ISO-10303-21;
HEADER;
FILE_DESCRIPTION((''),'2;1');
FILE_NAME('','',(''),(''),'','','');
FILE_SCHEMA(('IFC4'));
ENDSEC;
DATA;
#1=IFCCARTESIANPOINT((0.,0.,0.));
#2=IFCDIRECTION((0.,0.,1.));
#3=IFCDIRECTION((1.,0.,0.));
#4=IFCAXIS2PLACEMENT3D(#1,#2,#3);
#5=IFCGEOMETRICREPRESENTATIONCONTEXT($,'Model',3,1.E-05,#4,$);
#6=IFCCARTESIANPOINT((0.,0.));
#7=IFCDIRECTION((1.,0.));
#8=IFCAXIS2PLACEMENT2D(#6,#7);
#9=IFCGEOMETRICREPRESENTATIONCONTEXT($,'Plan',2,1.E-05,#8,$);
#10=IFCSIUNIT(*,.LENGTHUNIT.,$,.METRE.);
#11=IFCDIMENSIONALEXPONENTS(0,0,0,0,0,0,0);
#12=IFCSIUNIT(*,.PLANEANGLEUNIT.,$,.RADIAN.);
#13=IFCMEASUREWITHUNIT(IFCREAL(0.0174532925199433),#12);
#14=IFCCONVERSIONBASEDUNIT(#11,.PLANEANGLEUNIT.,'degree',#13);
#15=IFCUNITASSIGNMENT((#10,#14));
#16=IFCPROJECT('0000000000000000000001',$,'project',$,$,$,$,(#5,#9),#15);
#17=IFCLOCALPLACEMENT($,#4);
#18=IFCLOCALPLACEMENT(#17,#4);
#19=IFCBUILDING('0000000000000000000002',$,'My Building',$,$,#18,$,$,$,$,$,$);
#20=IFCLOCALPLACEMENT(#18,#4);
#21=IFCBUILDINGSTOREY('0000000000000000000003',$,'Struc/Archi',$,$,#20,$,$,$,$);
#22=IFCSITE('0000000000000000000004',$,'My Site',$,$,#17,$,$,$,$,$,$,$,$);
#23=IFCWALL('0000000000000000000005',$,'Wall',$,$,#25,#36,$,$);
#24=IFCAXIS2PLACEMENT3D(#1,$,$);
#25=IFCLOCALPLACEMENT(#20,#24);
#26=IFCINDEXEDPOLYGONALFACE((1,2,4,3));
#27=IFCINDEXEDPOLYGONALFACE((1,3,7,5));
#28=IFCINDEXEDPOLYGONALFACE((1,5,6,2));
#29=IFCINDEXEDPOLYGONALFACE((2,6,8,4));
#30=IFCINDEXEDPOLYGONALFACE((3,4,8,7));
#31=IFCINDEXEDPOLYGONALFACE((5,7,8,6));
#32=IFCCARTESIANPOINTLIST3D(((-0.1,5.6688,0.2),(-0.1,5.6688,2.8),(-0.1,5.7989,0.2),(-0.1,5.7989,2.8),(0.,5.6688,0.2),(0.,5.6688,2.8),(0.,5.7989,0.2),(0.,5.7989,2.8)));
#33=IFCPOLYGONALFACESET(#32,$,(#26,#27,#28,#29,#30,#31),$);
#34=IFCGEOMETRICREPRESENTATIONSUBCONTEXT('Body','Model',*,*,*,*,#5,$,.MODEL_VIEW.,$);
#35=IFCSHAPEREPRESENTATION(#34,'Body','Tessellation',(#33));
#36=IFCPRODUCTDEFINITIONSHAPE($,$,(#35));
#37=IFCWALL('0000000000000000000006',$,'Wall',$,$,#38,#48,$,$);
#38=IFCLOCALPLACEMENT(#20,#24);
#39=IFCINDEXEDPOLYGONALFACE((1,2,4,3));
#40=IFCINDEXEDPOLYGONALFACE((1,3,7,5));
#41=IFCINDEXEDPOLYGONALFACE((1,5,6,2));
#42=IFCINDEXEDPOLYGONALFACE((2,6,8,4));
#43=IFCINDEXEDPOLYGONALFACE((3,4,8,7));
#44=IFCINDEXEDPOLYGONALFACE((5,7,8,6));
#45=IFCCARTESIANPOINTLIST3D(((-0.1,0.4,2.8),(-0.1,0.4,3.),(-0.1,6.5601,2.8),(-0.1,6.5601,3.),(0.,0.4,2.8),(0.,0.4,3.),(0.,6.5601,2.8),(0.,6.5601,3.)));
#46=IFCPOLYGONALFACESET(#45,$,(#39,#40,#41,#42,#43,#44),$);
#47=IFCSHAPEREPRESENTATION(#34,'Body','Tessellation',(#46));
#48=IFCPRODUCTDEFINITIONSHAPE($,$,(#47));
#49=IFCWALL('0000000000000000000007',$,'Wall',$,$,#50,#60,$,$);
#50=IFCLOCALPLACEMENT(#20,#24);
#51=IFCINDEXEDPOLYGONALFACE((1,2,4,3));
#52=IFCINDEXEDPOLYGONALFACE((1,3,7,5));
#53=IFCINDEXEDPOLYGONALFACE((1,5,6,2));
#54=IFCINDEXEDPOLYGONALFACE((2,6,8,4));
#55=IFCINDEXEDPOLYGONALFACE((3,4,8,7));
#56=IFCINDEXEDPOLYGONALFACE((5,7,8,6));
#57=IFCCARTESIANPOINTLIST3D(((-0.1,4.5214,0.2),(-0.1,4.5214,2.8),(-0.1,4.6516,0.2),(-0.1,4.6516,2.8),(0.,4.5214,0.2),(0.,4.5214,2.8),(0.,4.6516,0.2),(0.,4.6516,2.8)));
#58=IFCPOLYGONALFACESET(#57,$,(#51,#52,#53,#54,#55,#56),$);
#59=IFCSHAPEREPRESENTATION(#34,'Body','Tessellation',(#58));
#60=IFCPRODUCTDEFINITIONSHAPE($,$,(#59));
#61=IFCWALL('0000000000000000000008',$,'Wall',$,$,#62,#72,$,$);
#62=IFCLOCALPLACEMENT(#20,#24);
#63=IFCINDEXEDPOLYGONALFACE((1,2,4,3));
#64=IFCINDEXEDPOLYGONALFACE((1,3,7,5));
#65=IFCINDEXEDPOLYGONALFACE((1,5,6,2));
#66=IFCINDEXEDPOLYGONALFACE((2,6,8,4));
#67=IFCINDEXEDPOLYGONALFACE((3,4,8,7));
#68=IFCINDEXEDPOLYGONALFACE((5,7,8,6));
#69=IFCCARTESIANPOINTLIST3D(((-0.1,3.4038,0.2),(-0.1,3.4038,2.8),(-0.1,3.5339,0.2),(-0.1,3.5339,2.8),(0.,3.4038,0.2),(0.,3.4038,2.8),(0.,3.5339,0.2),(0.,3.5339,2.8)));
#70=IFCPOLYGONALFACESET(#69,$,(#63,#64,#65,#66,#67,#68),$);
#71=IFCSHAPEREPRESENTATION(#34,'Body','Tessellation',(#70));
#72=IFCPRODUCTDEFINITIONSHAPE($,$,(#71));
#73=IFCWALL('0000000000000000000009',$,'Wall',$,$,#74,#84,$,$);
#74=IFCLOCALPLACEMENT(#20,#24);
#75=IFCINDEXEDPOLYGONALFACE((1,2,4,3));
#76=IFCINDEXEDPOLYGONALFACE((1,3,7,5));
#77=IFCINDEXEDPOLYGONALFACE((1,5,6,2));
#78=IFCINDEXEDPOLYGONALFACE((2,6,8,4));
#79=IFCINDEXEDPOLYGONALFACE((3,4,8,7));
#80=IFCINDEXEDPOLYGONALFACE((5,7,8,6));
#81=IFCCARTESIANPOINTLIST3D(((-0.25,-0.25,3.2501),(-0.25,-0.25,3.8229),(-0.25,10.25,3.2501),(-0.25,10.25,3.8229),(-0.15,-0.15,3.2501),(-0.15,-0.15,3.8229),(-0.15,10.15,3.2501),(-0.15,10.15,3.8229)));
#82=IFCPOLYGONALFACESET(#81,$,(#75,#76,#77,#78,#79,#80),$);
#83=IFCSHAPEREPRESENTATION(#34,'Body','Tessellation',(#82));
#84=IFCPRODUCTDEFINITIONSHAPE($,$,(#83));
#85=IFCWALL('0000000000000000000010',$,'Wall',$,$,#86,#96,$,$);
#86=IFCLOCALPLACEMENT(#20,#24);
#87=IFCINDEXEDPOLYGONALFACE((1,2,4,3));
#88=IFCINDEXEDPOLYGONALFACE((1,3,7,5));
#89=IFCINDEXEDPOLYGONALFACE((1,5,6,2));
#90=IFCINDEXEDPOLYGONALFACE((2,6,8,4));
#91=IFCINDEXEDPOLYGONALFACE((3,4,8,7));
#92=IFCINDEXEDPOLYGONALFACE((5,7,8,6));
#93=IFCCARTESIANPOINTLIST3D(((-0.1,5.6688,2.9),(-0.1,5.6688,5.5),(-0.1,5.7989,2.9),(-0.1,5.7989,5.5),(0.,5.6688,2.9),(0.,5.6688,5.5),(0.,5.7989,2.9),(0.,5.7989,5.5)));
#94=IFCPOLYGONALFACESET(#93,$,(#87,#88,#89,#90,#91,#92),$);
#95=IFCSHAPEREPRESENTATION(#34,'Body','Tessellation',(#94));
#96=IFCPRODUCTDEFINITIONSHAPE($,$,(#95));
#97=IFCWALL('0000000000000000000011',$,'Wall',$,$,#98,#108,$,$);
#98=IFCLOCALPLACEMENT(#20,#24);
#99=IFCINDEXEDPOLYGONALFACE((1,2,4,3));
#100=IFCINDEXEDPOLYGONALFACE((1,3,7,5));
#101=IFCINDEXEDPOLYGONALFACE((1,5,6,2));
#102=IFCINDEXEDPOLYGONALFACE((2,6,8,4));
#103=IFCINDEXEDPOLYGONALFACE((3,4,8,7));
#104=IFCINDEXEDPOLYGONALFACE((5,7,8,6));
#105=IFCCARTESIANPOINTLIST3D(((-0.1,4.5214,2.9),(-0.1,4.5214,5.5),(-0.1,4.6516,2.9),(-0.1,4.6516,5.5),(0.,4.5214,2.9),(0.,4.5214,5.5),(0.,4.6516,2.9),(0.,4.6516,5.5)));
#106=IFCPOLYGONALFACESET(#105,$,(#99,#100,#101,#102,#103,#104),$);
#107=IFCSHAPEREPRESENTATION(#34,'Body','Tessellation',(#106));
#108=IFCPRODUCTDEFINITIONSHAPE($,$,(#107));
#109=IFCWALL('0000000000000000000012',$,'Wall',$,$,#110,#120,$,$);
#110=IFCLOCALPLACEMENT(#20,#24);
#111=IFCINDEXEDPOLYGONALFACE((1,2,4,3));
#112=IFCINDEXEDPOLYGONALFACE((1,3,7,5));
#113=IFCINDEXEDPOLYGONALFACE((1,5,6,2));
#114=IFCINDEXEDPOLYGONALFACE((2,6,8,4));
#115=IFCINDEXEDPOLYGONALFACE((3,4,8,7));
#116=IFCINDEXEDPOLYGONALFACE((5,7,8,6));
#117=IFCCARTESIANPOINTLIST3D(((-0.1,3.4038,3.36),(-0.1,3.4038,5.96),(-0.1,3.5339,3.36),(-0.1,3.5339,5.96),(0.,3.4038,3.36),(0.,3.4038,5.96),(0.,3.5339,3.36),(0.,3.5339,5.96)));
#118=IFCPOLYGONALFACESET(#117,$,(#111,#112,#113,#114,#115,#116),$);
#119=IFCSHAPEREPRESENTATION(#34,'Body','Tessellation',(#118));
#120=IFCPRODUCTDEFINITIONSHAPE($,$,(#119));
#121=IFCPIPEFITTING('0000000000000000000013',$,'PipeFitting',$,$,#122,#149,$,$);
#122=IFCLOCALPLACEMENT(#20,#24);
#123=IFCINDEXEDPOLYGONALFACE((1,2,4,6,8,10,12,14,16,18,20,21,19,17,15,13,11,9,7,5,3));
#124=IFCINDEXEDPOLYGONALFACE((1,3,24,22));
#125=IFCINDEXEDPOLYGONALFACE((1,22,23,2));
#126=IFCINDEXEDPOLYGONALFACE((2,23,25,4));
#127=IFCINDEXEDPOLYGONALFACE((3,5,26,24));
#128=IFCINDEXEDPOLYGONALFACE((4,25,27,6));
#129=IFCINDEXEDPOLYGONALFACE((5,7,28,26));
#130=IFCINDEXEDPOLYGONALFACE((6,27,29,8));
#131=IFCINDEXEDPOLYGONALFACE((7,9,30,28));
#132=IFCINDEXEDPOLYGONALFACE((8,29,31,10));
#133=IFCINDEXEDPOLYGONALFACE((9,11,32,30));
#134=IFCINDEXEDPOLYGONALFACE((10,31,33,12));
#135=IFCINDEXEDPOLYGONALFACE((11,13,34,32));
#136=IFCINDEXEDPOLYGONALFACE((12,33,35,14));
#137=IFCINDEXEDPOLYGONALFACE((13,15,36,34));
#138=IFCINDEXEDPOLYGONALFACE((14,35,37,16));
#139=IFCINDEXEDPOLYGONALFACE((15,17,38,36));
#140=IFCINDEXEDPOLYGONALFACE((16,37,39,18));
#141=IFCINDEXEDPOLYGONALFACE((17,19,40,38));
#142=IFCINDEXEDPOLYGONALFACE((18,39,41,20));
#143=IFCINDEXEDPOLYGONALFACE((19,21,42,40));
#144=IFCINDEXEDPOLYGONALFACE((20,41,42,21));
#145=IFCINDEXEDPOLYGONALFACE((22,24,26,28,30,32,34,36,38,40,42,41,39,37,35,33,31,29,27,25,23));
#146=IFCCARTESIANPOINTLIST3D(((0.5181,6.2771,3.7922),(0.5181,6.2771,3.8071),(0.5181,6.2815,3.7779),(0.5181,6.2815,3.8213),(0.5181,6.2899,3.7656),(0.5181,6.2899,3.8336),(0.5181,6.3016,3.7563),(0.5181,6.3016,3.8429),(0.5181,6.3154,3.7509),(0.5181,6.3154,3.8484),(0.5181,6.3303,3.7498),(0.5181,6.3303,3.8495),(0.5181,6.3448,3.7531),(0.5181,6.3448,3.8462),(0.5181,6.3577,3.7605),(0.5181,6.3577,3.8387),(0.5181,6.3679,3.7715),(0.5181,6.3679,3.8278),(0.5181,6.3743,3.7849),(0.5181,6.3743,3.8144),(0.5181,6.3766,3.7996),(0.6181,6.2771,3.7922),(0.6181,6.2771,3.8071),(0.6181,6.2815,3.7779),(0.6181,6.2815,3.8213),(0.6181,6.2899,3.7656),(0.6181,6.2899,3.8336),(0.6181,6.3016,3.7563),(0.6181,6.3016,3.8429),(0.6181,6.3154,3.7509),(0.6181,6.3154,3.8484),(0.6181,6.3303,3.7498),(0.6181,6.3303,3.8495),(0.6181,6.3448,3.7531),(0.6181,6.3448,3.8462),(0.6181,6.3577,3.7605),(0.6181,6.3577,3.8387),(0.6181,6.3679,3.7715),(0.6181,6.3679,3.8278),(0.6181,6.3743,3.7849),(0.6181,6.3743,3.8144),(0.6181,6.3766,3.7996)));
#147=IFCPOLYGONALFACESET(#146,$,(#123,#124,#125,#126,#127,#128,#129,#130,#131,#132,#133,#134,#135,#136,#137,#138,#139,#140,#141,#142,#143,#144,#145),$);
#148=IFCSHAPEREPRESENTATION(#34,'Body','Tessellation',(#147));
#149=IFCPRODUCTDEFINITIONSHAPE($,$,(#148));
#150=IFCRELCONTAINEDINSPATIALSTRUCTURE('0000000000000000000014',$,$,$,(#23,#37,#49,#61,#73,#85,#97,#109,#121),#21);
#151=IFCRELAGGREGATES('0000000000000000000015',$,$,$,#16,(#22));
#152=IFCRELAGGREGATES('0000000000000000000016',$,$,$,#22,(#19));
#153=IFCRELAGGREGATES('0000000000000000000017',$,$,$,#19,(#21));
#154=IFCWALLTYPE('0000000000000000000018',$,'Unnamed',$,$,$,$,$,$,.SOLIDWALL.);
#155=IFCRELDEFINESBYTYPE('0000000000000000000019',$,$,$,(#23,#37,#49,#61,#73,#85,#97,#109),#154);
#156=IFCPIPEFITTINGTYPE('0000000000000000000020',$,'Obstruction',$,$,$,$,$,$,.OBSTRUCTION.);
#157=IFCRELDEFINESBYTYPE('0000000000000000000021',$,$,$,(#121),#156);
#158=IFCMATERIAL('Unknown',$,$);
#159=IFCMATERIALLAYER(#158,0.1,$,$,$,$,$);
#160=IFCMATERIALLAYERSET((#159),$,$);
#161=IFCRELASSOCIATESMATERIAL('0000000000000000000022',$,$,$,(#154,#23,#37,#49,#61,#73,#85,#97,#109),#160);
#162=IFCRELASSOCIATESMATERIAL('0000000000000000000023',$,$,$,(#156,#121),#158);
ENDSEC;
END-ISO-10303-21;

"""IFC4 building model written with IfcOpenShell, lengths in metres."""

from ifc_helpers import new_model, entity, si_unit, converted_unit, frame, origin_with_axes, origin_2d_with_axis, place, context, subcontext, project, spatial, line, indexed_curve, circle, outline, extrude, material, layer, layer_set, layer_usage, material_profile, profile_set, profile_usage, type_object, element, save


model = new_model("IFC4")

# Units and contexts
model_context = context("Model", 3, precision=1e-05, world=origin_with_axes())
plan_context = context("Plan", 2, precision=1e-05, world=origin_2d_with_axis())
body_context_1 = subcontext(model_context, "Body", "Model", "MODEL_VIEW")
ifc_project = project(units=[si_unit("LENGTHUNIT", "METRE"), converted_unit("PLANEANGLEUNIT", "degree", entity("IfcReal", 0.0174532925199433), si_unit("PLANEANGLEUNIT", "RADIAN"), dimensions=[0, 0, 0, 0, 0, 0, 0])], contexts=[model_context, plan_context])

# Site, building, storey
site_placement = place(None, origin_with_axes())
site = spatial("IfcSite", under=ifc_project, at=site_placement, Name="My Site")
building_placement = place(site_placement, origin_with_axes())
building = spatial("IfcBuilding", under=site, at=building_placement, Name="My Building")
storey_placement = place(building_placement, origin_with_axes())
storey = spatial("IfcBuildingStorey", under=building, at=storey_placement, Name="Struc/Archi")

# Shared definitions
ifc_material = material(Name="Unknown")

# Shared definitions
ifc_layer_1 = layer(ifc_material, 0.1)
ifc_layer_set_1 = layer_set([ifc_layer_1])
wall_type = type_object("IfcWallType", Name="Unnamed", PredefinedType="SOLIDWALL", material=ifc_layer_set_1)

# Walls
ifc_layer_usage_1 = layer_usage(ifc_layer_set_1, "AXIS2", "POSITIVE", 0.0)
wall_1_placement = place(storey_placement, frame((-0.1, 5.7989, 0.2), z_axis=(0.0, 0.0, 1.0), x_axis=(0.0, -1.0, 0.0)))
element("IfcWall", 1, at=wall_1_placement, inside=storey, type_object=wall_type, material=ifc_layer_usage_1, Name="Wall", context=body_context_1, shape_type="SweptSolid", body=[
    extrude(outline(indexed_curve([(0.0, 0.0), (0.0, 0.1), (0.1301, 0.1), (0.1301, 0.0)], segments=[line(1, 2, 3, 4, 1)])), origin_with_axes(), (0.0, 0.0, 1.0), 2.6),
])
ifc_layer_usage_2 = layer_usage(ifc_layer_set_1, "AXIS2", "POSITIVE", 0.0)
wall_2_placement = place(storey_placement, frame((-0.1, 6.5601, 2.8), z_axis=(0.0, 0.0, 1.0), x_axis=(0.0, -1.0, 0.0)))
element("IfcWall", 2, at=wall_2_placement, inside=storey, type_object=wall_type, material=ifc_layer_usage_2, Name="Wall", context=body_context_1, shape_type="SweptSolid", body=[
    extrude(outline(indexed_curve([(0.0, 0.0), (0.0, 0.1), (6.1601, 0.1), (6.1601, 0.0)], segments=[line(1, 2, 3, 4, 1)])), origin_with_axes(), (0.0, 0.0, 1.0), 0.2),
])
ifc_layer_usage_3 = layer_usage(ifc_layer_set_1, "AXIS2", "POSITIVE", 0.0)
wall_3_placement = place(storey_placement, frame((-0.1, 4.6516, 0.2), z_axis=(0.0, 0.0, 1.0), x_axis=(0.0, -1.0, 0.0)))
element("IfcWall", 3, at=wall_3_placement, inside=storey, type_object=wall_type, material=ifc_layer_usage_3, Name="Wall", context=body_context_1, shape_type="SweptSolid", body=[
    extrude(outline(indexed_curve([(0.0, 0.0), (0.0, 0.1), (0.1301, 0.1), (0.1301, 0.0)], segments=[line(1, 2, 3, 4, 1)])), origin_with_axes(), (0.0, 0.0, 1.0), 2.6),
])
ifc_layer_usage_4 = layer_usage(ifc_layer_set_1, "AXIS2", "POSITIVE", 0.0)
wall_4_placement = place(storey_placement, frame((-0.1, 3.5339, 0.2), z_axis=(0.0, 0.0, 1.0), x_axis=(0.0, -1.0, 0.0)))
element("IfcWall", 4, at=wall_4_placement, inside=storey, type_object=wall_type, material=ifc_layer_usage_4, Name="Wall", context=body_context_1, shape_type="SweptSolid", body=[
    extrude(outline(indexed_curve([(0.0, 0.0), (0.0, 0.1), (0.1301, 0.1), (0.1301, 0.0)], segments=[line(1, 2, 3, 4, 1)])), origin_with_axes(), (0.0, 0.0, 1.0), 2.6),
])
ifc_layer_usage_5 = layer_usage(ifc_layer_set_1, "AXIS2", "POSITIVE", 0.0)
wall_5_placement = place(storey_placement, frame((-0.25, 10.25, 3.2501), z_axis=(0.0, 0.0, 1.0), x_axis=(0.0, -1.0, 0.0)))
element("IfcWall", 5, at=wall_5_placement, inside=storey, type_object=wall_type, material=ifc_layer_usage_5, Name="Wall", context=body_context_1, shape_type="SweptSolid", body=[
    extrude(outline(indexed_curve([(0.0, 0.0), (0.1, 0.1), (10.4, 0.1), (10.5, 0.0)], segments=[line(1, 2, 3, 4, 1)])), origin_with_axes(), (0.0, 0.0, 1.0), 0.5728),
])
ifc_layer_usage_6 = layer_usage(ifc_layer_set_1, "AXIS2", "POSITIVE", 0.0)
wall_6_placement = place(storey_placement, frame((-0.1, 5.7989, 2.9), z_axis=(0.0, 0.0, 1.0), x_axis=(0.0, -1.0, 0.0)))
element("IfcWall", 6, at=wall_6_placement, inside=storey, type_object=wall_type, material=ifc_layer_usage_6, Name="Wall", context=body_context_1, shape_type="SweptSolid", body=[
    extrude(outline(indexed_curve([(0.0, 0.0), (0.0, 0.1), (0.1301, 0.1), (0.1301, 0.0)], segments=[line(1, 2, 3, 4, 1)])), origin_with_axes(), (0.0, 0.0, 1.0), 2.6),
])
ifc_layer_usage_7 = layer_usage(ifc_layer_set_1, "AXIS2", "POSITIVE", 0.0)
wall_7_placement = place(storey_placement, frame((-0.1, 4.6516, 2.9), z_axis=(0.0, 0.0, 1.0), x_axis=(0.0, -1.0, 0.0)))
element("IfcWall", 7, at=wall_7_placement, inside=storey, type_object=wall_type, material=ifc_layer_usage_7, Name="Wall", context=body_context_1, shape_type="SweptSolid", body=[
    extrude(outline(indexed_curve([(0.0, 0.0), (0.0, 0.1), (0.1301, 0.1), (0.1301, 0.0)], segments=[line(1, 2, 3, 4, 1)])), origin_with_axes(), (0.0, 0.0, 1.0), 2.6),
])
ifc_layer_usage_8 = layer_usage(ifc_layer_set_1, "AXIS2", "POSITIVE", 0.0)
wall_8_placement = place(storey_placement, frame((-0.1, 3.5339, 3.36), z_axis=(0.0, 0.0, 1.0), x_axis=(0.0, -1.0, 0.0)))
element("IfcWall", 8, at=wall_8_placement, inside=storey, type_object=wall_type, material=ifc_layer_usage_8, Name="Wall", context=body_context_1, shape_type="SweptSolid", body=[
    extrude(outline(indexed_curve([(0.0, 0.0), (0.0, 0.1), (0.1301, 0.1), (0.1301, 0.0)], segments=[line(1, 2, 3, 4, 1)])), origin_with_axes(), (0.0, 0.0, 1.0), 2.6),
])

# Pipe fitting
ifc_material_profile_1 = material_profile(ifc_material, circle(Radius=0.05))
ifc_profile_set_1 = profile_set([ifc_material_profile_1])
ifc_profile_usage_1 = profile_usage(ifc_profile_set_1, cardinal=5)
pipe_fitting_type = type_object("IfcPipeFittingType", Name="Obstruction", PredefinedType="OBSTRUCTION", material=ifc_profile_set_1)
pipe_fitting_placement = place(storey_placement, frame((0.5181, 6.3266, 3.7996), z_axis=(1.0, 0.0, 0.0), x_axis=(0.0, 1.0, 0.0)))
element("IfcPipeFitting", 9, at=pipe_fitting_placement, inside=storey, type_object=pipe_fitting_type, material=ifc_profile_usage_1, Name="PipeFitting", context=body_context_1, shape_type="SweptSolid", body=[
    extrude(circle(Radius=0.05), origin_with_axes(), (0.0, 0.0, 1.0), 0.1),
])

save(model, "model.ifc")
